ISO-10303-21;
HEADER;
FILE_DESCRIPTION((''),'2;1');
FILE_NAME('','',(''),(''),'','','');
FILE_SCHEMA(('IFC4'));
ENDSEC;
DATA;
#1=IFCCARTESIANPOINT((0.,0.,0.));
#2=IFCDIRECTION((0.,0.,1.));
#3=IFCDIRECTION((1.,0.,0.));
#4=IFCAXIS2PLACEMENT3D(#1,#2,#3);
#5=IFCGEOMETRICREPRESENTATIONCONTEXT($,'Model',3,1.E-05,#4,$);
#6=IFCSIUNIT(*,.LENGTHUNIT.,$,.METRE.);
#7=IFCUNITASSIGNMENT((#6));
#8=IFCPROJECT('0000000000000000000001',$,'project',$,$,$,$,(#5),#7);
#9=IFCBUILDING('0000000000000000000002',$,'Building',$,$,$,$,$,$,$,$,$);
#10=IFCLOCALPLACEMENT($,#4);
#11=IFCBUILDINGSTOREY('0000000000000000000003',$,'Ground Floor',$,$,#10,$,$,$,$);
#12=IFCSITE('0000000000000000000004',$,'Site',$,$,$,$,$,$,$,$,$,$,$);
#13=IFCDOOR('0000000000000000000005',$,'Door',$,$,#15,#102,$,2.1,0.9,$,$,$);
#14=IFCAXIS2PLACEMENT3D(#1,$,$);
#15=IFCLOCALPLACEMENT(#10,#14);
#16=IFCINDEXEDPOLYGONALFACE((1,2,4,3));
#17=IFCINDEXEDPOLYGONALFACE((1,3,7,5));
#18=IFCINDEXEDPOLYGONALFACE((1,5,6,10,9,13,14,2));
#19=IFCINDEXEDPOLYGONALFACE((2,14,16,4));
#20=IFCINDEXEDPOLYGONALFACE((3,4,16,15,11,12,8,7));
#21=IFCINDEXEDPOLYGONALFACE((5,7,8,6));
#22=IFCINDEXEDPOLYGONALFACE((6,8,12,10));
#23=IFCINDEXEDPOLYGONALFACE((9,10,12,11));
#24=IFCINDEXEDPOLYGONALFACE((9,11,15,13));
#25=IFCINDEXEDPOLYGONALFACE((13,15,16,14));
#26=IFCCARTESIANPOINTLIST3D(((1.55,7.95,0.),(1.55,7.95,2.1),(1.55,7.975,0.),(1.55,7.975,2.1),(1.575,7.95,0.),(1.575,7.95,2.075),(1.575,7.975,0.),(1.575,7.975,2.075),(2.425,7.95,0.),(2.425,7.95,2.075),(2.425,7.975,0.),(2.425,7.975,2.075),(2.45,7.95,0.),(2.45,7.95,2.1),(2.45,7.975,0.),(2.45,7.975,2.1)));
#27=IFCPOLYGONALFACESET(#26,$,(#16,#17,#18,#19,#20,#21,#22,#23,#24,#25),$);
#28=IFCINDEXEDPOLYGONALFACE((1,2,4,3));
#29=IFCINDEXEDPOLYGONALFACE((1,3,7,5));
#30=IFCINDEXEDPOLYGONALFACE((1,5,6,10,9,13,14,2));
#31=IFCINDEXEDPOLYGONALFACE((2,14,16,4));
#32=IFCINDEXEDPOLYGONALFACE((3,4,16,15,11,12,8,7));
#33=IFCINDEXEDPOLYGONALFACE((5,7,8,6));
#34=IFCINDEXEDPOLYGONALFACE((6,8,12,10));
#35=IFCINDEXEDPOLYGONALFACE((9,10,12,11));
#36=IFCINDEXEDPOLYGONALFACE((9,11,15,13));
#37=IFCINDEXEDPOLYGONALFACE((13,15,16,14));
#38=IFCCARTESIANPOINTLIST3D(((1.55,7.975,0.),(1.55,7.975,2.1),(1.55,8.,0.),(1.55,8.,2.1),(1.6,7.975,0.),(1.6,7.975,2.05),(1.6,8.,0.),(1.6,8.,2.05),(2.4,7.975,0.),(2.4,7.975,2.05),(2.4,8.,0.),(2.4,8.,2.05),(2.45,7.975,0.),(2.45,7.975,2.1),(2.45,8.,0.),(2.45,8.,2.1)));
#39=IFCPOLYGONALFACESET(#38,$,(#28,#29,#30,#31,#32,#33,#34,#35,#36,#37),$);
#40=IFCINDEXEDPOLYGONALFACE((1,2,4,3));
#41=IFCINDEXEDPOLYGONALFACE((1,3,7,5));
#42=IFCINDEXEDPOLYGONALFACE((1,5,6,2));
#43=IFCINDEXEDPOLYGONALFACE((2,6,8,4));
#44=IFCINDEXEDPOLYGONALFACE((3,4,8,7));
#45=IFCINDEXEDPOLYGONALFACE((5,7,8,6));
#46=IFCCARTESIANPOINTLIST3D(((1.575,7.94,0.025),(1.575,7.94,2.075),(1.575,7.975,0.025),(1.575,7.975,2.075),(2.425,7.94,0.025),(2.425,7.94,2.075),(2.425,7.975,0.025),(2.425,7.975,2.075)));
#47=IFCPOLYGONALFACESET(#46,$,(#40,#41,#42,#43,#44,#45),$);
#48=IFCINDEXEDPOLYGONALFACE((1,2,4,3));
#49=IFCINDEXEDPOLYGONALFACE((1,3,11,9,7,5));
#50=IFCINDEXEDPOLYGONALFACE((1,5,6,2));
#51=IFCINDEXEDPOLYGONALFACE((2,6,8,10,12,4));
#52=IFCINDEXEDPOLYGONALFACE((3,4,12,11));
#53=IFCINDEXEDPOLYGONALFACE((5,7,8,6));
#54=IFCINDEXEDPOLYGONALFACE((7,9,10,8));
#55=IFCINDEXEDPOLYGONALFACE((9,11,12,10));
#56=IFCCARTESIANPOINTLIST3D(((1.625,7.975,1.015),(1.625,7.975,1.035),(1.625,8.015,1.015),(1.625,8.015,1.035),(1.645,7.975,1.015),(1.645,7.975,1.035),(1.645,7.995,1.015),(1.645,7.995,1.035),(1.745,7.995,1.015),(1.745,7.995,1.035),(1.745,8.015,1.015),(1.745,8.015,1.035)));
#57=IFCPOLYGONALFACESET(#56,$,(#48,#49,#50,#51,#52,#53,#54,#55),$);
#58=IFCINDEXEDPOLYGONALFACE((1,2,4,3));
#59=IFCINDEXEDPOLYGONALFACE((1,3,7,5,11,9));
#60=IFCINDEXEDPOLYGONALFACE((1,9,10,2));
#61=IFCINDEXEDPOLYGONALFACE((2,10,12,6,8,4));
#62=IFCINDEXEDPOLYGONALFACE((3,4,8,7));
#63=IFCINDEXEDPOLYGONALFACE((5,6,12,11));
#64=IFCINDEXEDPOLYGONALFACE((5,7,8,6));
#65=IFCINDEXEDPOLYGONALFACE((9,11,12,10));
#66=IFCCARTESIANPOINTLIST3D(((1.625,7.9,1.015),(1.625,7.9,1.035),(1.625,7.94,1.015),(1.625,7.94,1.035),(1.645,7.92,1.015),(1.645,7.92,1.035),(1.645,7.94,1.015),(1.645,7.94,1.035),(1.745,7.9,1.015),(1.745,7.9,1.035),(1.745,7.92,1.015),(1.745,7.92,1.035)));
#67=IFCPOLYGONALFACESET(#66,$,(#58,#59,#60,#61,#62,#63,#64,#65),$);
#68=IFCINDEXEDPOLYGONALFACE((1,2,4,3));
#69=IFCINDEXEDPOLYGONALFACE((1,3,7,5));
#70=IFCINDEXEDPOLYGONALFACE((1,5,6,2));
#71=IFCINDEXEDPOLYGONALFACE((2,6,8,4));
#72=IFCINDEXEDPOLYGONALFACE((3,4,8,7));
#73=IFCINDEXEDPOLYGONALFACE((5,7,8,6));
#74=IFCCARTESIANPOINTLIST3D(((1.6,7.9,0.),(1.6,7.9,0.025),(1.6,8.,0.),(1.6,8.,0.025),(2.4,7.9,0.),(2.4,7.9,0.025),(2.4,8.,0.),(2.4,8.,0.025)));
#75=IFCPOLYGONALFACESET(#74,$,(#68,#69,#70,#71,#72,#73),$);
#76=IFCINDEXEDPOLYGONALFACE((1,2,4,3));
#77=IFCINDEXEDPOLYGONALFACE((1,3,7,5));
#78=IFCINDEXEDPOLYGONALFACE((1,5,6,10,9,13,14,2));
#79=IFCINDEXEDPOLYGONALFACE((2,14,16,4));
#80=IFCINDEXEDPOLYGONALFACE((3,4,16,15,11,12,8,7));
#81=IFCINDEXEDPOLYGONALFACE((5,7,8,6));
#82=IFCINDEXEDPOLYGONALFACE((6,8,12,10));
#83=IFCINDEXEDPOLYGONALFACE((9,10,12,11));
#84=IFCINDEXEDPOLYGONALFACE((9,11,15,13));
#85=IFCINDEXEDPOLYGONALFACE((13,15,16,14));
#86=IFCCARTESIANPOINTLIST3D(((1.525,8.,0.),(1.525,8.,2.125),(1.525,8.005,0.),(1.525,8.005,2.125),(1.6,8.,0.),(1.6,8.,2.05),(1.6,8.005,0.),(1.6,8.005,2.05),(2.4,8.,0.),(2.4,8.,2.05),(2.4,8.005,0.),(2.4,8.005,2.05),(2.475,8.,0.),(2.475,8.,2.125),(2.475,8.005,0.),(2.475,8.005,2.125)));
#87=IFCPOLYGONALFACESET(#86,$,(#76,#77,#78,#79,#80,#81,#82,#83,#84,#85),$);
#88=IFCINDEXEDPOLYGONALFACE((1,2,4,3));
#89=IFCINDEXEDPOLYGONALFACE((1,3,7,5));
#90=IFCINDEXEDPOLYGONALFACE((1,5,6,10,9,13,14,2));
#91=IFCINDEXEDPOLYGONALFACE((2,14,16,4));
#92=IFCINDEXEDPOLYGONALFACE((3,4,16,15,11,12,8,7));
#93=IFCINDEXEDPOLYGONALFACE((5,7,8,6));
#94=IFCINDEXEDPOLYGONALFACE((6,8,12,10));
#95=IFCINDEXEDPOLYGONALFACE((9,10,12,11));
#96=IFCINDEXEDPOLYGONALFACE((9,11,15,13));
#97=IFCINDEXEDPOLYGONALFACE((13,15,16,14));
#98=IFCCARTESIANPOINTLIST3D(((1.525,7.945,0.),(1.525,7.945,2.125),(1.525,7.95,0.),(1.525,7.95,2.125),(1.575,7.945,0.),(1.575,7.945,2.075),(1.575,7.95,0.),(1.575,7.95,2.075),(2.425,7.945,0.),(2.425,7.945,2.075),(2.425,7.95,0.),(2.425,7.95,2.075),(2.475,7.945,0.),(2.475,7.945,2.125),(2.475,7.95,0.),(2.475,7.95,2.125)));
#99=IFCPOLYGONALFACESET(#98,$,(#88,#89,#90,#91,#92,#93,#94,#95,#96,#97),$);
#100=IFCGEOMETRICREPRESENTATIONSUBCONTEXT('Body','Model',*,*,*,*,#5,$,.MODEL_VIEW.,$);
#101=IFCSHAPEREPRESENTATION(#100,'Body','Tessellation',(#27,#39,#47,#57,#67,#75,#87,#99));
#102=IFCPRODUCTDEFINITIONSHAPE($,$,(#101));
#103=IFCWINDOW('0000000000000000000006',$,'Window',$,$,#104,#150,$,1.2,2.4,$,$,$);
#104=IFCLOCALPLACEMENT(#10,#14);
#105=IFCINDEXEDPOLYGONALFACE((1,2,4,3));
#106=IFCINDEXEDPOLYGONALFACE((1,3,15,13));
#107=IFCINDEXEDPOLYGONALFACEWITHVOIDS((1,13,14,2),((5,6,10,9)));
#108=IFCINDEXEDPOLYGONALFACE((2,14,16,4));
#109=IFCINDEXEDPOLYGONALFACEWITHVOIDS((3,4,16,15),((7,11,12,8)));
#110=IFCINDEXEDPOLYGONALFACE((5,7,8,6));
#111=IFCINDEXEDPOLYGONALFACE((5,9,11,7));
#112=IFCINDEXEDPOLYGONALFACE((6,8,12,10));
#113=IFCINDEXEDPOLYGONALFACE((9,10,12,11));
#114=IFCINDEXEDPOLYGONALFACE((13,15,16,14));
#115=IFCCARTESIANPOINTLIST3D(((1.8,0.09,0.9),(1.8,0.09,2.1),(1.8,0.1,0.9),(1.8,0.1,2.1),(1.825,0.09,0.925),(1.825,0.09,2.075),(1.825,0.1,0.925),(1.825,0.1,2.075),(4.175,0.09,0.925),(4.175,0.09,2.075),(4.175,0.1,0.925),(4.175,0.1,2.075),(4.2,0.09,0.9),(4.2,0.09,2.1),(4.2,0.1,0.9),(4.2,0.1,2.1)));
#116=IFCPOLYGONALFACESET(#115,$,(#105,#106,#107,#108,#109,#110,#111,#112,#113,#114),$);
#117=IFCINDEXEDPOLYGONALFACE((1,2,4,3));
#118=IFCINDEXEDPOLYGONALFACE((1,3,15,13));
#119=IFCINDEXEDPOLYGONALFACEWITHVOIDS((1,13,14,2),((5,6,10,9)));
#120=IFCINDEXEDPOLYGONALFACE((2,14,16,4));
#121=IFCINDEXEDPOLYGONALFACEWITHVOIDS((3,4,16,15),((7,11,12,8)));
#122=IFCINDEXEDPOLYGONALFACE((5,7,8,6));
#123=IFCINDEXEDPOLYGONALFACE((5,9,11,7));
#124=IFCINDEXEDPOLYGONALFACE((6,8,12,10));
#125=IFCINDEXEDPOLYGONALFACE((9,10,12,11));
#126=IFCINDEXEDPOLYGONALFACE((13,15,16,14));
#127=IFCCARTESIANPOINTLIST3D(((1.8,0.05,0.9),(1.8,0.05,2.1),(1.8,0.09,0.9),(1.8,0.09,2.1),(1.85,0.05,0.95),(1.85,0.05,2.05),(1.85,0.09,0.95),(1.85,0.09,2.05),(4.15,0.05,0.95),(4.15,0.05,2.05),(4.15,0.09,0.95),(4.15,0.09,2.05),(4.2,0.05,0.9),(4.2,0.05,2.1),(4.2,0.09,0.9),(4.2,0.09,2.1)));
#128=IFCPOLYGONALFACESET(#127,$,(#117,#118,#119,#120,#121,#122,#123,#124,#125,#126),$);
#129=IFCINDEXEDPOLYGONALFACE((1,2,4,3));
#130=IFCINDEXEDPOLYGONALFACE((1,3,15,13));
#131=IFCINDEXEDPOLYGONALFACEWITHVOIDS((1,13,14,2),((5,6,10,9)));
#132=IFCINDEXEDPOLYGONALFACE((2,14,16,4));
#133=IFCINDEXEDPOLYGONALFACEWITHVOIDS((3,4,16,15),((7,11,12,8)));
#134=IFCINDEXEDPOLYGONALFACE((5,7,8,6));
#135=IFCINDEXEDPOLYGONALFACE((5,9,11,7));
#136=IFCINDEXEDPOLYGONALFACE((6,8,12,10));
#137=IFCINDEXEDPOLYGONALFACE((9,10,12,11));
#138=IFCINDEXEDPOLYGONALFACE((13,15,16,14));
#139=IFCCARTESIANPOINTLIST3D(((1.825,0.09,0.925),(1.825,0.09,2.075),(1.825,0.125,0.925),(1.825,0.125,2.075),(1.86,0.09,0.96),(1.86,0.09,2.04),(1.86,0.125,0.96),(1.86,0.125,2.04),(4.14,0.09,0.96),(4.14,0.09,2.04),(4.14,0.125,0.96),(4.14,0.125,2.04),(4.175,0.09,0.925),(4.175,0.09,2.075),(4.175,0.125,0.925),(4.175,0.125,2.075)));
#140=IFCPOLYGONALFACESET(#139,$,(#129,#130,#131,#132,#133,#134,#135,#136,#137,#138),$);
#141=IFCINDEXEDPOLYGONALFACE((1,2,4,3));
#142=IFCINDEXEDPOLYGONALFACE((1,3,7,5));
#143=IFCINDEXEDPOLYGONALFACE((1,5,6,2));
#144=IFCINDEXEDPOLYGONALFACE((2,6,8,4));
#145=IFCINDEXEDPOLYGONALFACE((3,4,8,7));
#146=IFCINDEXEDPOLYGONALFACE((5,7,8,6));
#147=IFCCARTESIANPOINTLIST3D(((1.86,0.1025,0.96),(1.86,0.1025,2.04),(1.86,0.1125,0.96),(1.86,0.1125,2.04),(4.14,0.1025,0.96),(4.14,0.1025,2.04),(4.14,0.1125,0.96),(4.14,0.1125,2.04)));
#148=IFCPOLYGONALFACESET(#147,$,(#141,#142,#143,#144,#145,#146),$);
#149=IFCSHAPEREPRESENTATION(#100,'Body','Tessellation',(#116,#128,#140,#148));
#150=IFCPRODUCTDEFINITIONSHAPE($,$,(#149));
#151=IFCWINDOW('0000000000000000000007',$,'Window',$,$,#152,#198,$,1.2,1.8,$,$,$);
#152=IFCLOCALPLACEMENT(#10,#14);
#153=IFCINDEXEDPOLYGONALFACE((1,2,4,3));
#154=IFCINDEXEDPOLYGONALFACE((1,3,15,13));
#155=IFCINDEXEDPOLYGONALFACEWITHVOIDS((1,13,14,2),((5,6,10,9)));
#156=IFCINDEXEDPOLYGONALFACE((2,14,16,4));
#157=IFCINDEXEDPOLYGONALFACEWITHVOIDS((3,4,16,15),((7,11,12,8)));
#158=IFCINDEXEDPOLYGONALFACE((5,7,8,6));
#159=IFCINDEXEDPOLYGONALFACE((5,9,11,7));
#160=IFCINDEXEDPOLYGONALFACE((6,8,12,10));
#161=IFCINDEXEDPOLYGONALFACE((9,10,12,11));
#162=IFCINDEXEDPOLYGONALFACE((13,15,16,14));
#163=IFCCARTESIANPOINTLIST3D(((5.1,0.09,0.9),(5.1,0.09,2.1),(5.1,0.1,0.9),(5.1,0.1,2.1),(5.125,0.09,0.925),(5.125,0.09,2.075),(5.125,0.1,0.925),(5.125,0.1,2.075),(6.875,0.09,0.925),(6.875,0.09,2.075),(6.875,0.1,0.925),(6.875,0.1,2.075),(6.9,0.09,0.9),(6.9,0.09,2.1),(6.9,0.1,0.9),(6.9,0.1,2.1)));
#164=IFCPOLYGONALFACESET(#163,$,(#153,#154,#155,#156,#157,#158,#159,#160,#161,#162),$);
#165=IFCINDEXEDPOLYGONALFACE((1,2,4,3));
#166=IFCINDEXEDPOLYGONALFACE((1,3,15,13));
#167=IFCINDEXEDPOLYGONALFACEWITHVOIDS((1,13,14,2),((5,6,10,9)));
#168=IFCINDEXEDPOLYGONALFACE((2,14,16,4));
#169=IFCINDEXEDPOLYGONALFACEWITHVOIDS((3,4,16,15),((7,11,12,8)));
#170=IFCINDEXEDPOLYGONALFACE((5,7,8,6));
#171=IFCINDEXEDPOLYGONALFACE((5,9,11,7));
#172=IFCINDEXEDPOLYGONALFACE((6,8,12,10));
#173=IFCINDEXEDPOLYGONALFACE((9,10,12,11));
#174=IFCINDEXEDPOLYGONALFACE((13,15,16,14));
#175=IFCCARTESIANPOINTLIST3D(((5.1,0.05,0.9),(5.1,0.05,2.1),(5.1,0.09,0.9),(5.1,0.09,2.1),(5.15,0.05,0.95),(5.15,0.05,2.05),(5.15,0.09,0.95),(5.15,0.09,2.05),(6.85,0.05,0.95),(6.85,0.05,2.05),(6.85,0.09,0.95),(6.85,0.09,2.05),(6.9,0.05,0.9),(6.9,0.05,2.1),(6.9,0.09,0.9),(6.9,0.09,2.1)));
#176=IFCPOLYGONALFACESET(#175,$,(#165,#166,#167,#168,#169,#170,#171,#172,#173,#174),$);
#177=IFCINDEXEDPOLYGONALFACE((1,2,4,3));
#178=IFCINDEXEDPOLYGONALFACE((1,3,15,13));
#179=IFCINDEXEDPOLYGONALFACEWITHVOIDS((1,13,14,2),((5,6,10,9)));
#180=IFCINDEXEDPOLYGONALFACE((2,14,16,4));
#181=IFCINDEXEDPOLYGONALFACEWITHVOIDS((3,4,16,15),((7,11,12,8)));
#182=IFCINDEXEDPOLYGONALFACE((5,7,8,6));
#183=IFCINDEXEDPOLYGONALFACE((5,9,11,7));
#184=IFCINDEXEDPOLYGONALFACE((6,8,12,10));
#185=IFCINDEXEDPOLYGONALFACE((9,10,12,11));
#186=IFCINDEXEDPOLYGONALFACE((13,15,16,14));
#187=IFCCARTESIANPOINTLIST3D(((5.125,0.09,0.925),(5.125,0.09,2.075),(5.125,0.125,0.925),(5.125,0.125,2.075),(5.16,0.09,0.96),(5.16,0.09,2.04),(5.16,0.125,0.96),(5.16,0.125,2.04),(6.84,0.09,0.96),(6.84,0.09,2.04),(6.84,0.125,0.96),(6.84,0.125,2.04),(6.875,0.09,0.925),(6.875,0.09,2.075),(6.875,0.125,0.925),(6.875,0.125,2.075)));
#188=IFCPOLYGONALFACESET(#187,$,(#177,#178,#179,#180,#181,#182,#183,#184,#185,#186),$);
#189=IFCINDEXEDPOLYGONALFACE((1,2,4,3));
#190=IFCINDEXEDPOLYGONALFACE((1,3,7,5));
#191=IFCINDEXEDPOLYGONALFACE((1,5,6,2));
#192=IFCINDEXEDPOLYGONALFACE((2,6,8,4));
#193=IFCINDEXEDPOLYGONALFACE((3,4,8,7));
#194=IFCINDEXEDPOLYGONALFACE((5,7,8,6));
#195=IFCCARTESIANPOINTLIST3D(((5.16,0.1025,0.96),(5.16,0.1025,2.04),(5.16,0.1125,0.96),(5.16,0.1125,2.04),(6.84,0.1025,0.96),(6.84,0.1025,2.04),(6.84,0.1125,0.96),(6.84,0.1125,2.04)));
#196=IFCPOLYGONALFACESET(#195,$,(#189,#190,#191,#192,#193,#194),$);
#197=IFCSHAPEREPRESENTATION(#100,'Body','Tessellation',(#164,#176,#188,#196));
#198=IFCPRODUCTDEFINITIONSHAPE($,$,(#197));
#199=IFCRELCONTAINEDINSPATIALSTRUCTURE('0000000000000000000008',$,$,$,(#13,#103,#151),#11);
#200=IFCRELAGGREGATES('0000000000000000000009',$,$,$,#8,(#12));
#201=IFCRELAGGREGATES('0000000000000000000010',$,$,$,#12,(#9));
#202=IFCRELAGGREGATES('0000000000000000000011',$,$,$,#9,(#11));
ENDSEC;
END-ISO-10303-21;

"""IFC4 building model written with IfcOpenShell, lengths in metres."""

from ifc_helpers import new_model, si_unit, frame, origin_with_axes, place, context, subcontext, project, spatial, line, indexed_curve, outline, extrude, element, save


model = new_model("IFC4")

# Units and contexts
model_context = context("Model", 3, precision=1e-05, world=origin_with_axes())
body_context = subcontext(model_context, "Body", "Model", "MODEL_VIEW")
ifc_project = project(units=[si_unit("LENGTHUNIT", "METRE")], contexts=[model_context])

# Site, building, storey
site = spatial("IfcSite", under=ifc_project, Name="Site")
building = spatial("IfcBuilding", under=site, Name="Building")
storey_placement = place(None, origin_with_axes())
storey = spatial("IfcBuildingStorey", under=building, at=storey_placement, Name="Ground Floor")

# Door
door_1_placement = place(storey_placement, frame((2.45, 8.0, 0.0), z_axis=(0.0, 0.0, 1.0), x_axis=(-1.0, 0.0, 0.0)))
element("IfcDoor", 1, at=door_1_placement, inside=storey, Name="Door", OverallHeight=2.1, OverallWidth=0.9, context=body_context, shape_type="SweptSolid", body=[
    extrude(outline(indexed_curve([(0.0, 0.0), (0.0, 2.1), (0.9, 2.1), (0.9, 0.0), (0.875, 0.0), (0.875, 2.075), (0.025, 2.075), (0.025, 0.0)], segments=[line(1, 2, 3, 4, 5, 6, 7, 8, 1)])), frame((0.0, 0.025, 0.0), z_axis=(0.0, -1.0, 0.0), x_axis=(1.0, 0.0, 0.0)), (0.0, 0.0, -1.0), 0.025),
    extrude(outline(indexed_curve([(0.0, 0.0), (0.0, 2.1), (0.9, 2.1), (0.9, 0.0), (0.85, 0.0), (0.85, 2.05), (0.05, 2.05), (0.05, 0.0)], segments=[line(1, 2, 3, 4, 5, 6, 7, 8, 1)])), frame((0.0, 0.0, 0.0), z_axis=(0.0, -1.0, 0.0), x_axis=(1.0, 0.0, 0.0)), (0.0, 0.0, -1.0), 0.025),
    extrude(outline(indexed_curve([(0.0, 0.0), (0.85, 0.0), (0.85, 0.035), (0.0, 0.035)], segments=[line(1, 2, 3, 4, 1)])), frame((0.025, 0.025, 0.025), z_axis=(0.0, 0.0, 1.0), x_axis=(1.0, 0.0, 0.0)), (0.0, 0.0, 1.0), 2.05),
    extrude(outline(indexed_curve([(0.0, 0.0), (0.0, -0.04), (-0.12, -0.04), (-0.12, -0.02), (-0.02, -0.02), (-0.02, 0.0)], segments=[line(1, 2, 3, 4, 5, 6, 1)])), frame((0.825, 0.025, 1.015), z_axis=(0.0, 0.0, 1.0), x_axis=(1.0, 0.0, 0.0)), (0.0, 0.0, 1.0), 0.02),
    extrude(outline(indexed_curve([(0.0, 0.0), (0.0, 0.04), (-0.12, 0.04), (-0.12, 0.02), (-0.02, 0.02), (-0.02, 0.0)], segments=[line(1, 2, 3, 4, 5, 6, 1)])), frame((0.825, 0.06, 1.015), z_axis=(0.0, 0.0, 1.0), x_axis=(1.0, 0.0, 0.0)), (0.0, 0.0, 1.0), 0.02),
    extrude(outline(indexed_curve([(0.0, 0.0), (0.8, 0.0), (0.8, 0.1), (0.0, 0.1)], segments=[line(1, 2, 3, 4, 1)])), frame((0.05, 0.0, 0.0), z_axis=(0.0, 0.0, 1.0), x_axis=(1.0, 0.0, 0.0)), (0.0, 0.0, 1.0), 0.025),
    extrude(outline(indexed_curve([(0.0, 0.0), (0.0, 2.125), (0.95, 2.125), (0.95, 0.0), (0.875, 0.0), (0.875, 2.05), (0.075, 2.05), (0.075, 0.0)], segments=[line(1, 2, 3, 4, 5, 6, 7, 8, 1)])), frame((-0.025, -0.005, 0.0), z_axis=(0.0, -1.0, 0.0), x_axis=(1.0, 0.0, 0.0)), (0.0, 0.0, -1.0), 0.005),
    extrude(outline(indexed_curve([(0.0, 0.0), (0.0, 2.125), (0.95, 2.125), (0.95, 0.0), (0.9, 0.0), (0.9, 2.075), (0.05, 2.075), (0.05, 0.0)], segments=[line(1, 2, 3, 4, 5, 6, 7, 8, 1)])), frame((-0.025, 0.05, 0.0), z_axis=(0.0, -1.0, 0.0), x_axis=(1.0, 0.0, 0.0)), (0.0, 0.0, -1.0), 0.005),
])

# Windows
window_1_placement = place(storey_placement, frame((1.8, 0.0, 0.9), z_axis=(0.0, 0.0, 1.0), x_axis=(1.0, 0.0, 0.0)))
element("IfcWindow", 2, at=window_1_placement, inside=storey, Name="Window", OverallHeight=1.2, OverallWidth=2.4, context=body_context, shape_type="SweptSolid", body=[
    extrude(outline(indexed_curve([(0.0, 0.0), (2.4, 0.0), (2.4, 1.2), (0.0, 1.2)], segments=[line(1, 2, 3, 4, 1)]), holes=[indexed_curve([(0.025, 0.025), (2.375, 0.025), (2.375, 1.175), (0.025, 1.175)], segments=[line(1, 2, 3, 4, 1)])]), frame((0.0, 0.09, 0.0), z_axis=(0.0, -1.0, 0.0), x_axis=(1.0, 0.0, 0.0)), (0.0, 0.0, -1.0), 0.01),
    extrude(outline(indexed_curve([(0.0, 0.0), (2.4, 0.0), (2.4, 1.2), (0.0, 1.2)], segments=[line(1, 2, 3, 4, 1)]), holes=[indexed_curve([(0.05, 0.05), (2.35, 0.05), (2.35, 1.15), (0.05, 1.15)], segments=[line(1, 2, 3, 4, 1)])]), frame((0.0, 0.05, 0.0), z_axis=(0.0, -1.0, 0.0), x_axis=(1.0, 0.0, 0.0)), (0.0, 0.0, -1.0), 0.04),
    extrude(outline(indexed_curve([(0.0, 0.0), (2.35, 0.0), (2.35, 1.15), (0.0, 1.15)], segments=[line(1, 2, 3, 4, 1)]), holes=[indexed_curve([(0.035, 0.035), (2.315, 0.035), (2.315, 1.115), (0.035, 1.115)], segments=[line(1, 2, 3, 4, 1)])]), frame((0.025, 0.09, 0.025), z_axis=(0.0, -1.0, 0.0), x_axis=(1.0, 0.0, 0.0)), (0.0, 0.0, -1.0), 0.035),
    extrude(outline(indexed_curve([(0.035, 0.035), (2.315, 0.035), (2.315, 1.115), (0.035, 1.115)], segments=[line(1, 2, 3, 4, 1)])), frame((0.025, 0.1025, 0.025), z_axis=(0.0, -1.0, 0.0), x_axis=(1.0, 0.0, 0.0)), (0.0, 0.0, -1.0), 0.01),
])
window_2_placement = place(storey_placement, frame((5.1, 0.0, 0.9), z_axis=(0.0, 0.0, 1.0), x_axis=(1.0, 0.0, 0.0)))
element("IfcWindow", 3, at=window_2_placement, inside=storey, Name="Window", OverallHeight=1.2, OverallWidth=1.8, context=body_context, shape_type="SweptSolid", body=[
    extrude(outline(indexed_curve([(0.0, 0.0), (1.8, 0.0), (1.8, 1.2), (0.0, 1.2)], segments=[line(1, 2, 3, 4, 1)]), holes=[indexed_curve([(0.025, 0.025), (1.775, 0.025), (1.775, 1.175), (0.025, 1.175)], segments=[line(1, 2, 3, 4, 1)])]), frame((0.0, 0.09, 0.0), z_axis=(0.0, -1.0, 0.0), x_axis=(1.0, 0.0, 0.0)), (0.0, 0.0, -1.0), 0.01),
    extrude(outline(indexed_curve([(0.0, 0.0), (1.8, 0.0), (1.8, 1.2), (0.0, 1.2)], segments=[line(1, 2, 3, 4, 1)]), holes=[indexed_curve([(0.05, 0.05), (1.75, 0.05), (1.75, 1.15), (0.05, 1.15)], segments=[line(1, 2, 3, 4, 1)])]), frame((0.0, 0.05, 0.0), z_axis=(0.0, -1.0, 0.0), x_axis=(1.0, 0.0, 0.0)), (0.0, 0.0, -1.0), 0.04),
    extrude(outline(indexed_curve([(0.0, 0.0), (1.75, 0.0), (1.75, 1.15), (0.0, 1.15)], segments=[line(1, 2, 3, 4, 1)]), holes=[indexed_curve([(0.035, 0.035), (1.715, 0.035), (1.715, 1.115), (0.035, 1.115)], segments=[line(1, 2, 3, 4, 1)])]), frame((0.025, 0.09, 0.025), z_axis=(0.0, -1.0, 0.0), x_axis=(1.0, 0.0, 0.0)), (0.0, 0.0, -1.0), 0.035),
    extrude(outline(indexed_curve([(0.035, 0.035), (1.715, 0.035), (1.715, 1.115), (0.035, 1.115)], segments=[line(1, 2, 3, 4, 1)])), frame((0.025, 0.1025, 0.025), z_axis=(0.0, -1.0, 0.0), x_axis=(1.0, 0.0, 0.0)), (0.0, 0.0, -1.0), 0.01),
])

save(model, "model.ifc")
